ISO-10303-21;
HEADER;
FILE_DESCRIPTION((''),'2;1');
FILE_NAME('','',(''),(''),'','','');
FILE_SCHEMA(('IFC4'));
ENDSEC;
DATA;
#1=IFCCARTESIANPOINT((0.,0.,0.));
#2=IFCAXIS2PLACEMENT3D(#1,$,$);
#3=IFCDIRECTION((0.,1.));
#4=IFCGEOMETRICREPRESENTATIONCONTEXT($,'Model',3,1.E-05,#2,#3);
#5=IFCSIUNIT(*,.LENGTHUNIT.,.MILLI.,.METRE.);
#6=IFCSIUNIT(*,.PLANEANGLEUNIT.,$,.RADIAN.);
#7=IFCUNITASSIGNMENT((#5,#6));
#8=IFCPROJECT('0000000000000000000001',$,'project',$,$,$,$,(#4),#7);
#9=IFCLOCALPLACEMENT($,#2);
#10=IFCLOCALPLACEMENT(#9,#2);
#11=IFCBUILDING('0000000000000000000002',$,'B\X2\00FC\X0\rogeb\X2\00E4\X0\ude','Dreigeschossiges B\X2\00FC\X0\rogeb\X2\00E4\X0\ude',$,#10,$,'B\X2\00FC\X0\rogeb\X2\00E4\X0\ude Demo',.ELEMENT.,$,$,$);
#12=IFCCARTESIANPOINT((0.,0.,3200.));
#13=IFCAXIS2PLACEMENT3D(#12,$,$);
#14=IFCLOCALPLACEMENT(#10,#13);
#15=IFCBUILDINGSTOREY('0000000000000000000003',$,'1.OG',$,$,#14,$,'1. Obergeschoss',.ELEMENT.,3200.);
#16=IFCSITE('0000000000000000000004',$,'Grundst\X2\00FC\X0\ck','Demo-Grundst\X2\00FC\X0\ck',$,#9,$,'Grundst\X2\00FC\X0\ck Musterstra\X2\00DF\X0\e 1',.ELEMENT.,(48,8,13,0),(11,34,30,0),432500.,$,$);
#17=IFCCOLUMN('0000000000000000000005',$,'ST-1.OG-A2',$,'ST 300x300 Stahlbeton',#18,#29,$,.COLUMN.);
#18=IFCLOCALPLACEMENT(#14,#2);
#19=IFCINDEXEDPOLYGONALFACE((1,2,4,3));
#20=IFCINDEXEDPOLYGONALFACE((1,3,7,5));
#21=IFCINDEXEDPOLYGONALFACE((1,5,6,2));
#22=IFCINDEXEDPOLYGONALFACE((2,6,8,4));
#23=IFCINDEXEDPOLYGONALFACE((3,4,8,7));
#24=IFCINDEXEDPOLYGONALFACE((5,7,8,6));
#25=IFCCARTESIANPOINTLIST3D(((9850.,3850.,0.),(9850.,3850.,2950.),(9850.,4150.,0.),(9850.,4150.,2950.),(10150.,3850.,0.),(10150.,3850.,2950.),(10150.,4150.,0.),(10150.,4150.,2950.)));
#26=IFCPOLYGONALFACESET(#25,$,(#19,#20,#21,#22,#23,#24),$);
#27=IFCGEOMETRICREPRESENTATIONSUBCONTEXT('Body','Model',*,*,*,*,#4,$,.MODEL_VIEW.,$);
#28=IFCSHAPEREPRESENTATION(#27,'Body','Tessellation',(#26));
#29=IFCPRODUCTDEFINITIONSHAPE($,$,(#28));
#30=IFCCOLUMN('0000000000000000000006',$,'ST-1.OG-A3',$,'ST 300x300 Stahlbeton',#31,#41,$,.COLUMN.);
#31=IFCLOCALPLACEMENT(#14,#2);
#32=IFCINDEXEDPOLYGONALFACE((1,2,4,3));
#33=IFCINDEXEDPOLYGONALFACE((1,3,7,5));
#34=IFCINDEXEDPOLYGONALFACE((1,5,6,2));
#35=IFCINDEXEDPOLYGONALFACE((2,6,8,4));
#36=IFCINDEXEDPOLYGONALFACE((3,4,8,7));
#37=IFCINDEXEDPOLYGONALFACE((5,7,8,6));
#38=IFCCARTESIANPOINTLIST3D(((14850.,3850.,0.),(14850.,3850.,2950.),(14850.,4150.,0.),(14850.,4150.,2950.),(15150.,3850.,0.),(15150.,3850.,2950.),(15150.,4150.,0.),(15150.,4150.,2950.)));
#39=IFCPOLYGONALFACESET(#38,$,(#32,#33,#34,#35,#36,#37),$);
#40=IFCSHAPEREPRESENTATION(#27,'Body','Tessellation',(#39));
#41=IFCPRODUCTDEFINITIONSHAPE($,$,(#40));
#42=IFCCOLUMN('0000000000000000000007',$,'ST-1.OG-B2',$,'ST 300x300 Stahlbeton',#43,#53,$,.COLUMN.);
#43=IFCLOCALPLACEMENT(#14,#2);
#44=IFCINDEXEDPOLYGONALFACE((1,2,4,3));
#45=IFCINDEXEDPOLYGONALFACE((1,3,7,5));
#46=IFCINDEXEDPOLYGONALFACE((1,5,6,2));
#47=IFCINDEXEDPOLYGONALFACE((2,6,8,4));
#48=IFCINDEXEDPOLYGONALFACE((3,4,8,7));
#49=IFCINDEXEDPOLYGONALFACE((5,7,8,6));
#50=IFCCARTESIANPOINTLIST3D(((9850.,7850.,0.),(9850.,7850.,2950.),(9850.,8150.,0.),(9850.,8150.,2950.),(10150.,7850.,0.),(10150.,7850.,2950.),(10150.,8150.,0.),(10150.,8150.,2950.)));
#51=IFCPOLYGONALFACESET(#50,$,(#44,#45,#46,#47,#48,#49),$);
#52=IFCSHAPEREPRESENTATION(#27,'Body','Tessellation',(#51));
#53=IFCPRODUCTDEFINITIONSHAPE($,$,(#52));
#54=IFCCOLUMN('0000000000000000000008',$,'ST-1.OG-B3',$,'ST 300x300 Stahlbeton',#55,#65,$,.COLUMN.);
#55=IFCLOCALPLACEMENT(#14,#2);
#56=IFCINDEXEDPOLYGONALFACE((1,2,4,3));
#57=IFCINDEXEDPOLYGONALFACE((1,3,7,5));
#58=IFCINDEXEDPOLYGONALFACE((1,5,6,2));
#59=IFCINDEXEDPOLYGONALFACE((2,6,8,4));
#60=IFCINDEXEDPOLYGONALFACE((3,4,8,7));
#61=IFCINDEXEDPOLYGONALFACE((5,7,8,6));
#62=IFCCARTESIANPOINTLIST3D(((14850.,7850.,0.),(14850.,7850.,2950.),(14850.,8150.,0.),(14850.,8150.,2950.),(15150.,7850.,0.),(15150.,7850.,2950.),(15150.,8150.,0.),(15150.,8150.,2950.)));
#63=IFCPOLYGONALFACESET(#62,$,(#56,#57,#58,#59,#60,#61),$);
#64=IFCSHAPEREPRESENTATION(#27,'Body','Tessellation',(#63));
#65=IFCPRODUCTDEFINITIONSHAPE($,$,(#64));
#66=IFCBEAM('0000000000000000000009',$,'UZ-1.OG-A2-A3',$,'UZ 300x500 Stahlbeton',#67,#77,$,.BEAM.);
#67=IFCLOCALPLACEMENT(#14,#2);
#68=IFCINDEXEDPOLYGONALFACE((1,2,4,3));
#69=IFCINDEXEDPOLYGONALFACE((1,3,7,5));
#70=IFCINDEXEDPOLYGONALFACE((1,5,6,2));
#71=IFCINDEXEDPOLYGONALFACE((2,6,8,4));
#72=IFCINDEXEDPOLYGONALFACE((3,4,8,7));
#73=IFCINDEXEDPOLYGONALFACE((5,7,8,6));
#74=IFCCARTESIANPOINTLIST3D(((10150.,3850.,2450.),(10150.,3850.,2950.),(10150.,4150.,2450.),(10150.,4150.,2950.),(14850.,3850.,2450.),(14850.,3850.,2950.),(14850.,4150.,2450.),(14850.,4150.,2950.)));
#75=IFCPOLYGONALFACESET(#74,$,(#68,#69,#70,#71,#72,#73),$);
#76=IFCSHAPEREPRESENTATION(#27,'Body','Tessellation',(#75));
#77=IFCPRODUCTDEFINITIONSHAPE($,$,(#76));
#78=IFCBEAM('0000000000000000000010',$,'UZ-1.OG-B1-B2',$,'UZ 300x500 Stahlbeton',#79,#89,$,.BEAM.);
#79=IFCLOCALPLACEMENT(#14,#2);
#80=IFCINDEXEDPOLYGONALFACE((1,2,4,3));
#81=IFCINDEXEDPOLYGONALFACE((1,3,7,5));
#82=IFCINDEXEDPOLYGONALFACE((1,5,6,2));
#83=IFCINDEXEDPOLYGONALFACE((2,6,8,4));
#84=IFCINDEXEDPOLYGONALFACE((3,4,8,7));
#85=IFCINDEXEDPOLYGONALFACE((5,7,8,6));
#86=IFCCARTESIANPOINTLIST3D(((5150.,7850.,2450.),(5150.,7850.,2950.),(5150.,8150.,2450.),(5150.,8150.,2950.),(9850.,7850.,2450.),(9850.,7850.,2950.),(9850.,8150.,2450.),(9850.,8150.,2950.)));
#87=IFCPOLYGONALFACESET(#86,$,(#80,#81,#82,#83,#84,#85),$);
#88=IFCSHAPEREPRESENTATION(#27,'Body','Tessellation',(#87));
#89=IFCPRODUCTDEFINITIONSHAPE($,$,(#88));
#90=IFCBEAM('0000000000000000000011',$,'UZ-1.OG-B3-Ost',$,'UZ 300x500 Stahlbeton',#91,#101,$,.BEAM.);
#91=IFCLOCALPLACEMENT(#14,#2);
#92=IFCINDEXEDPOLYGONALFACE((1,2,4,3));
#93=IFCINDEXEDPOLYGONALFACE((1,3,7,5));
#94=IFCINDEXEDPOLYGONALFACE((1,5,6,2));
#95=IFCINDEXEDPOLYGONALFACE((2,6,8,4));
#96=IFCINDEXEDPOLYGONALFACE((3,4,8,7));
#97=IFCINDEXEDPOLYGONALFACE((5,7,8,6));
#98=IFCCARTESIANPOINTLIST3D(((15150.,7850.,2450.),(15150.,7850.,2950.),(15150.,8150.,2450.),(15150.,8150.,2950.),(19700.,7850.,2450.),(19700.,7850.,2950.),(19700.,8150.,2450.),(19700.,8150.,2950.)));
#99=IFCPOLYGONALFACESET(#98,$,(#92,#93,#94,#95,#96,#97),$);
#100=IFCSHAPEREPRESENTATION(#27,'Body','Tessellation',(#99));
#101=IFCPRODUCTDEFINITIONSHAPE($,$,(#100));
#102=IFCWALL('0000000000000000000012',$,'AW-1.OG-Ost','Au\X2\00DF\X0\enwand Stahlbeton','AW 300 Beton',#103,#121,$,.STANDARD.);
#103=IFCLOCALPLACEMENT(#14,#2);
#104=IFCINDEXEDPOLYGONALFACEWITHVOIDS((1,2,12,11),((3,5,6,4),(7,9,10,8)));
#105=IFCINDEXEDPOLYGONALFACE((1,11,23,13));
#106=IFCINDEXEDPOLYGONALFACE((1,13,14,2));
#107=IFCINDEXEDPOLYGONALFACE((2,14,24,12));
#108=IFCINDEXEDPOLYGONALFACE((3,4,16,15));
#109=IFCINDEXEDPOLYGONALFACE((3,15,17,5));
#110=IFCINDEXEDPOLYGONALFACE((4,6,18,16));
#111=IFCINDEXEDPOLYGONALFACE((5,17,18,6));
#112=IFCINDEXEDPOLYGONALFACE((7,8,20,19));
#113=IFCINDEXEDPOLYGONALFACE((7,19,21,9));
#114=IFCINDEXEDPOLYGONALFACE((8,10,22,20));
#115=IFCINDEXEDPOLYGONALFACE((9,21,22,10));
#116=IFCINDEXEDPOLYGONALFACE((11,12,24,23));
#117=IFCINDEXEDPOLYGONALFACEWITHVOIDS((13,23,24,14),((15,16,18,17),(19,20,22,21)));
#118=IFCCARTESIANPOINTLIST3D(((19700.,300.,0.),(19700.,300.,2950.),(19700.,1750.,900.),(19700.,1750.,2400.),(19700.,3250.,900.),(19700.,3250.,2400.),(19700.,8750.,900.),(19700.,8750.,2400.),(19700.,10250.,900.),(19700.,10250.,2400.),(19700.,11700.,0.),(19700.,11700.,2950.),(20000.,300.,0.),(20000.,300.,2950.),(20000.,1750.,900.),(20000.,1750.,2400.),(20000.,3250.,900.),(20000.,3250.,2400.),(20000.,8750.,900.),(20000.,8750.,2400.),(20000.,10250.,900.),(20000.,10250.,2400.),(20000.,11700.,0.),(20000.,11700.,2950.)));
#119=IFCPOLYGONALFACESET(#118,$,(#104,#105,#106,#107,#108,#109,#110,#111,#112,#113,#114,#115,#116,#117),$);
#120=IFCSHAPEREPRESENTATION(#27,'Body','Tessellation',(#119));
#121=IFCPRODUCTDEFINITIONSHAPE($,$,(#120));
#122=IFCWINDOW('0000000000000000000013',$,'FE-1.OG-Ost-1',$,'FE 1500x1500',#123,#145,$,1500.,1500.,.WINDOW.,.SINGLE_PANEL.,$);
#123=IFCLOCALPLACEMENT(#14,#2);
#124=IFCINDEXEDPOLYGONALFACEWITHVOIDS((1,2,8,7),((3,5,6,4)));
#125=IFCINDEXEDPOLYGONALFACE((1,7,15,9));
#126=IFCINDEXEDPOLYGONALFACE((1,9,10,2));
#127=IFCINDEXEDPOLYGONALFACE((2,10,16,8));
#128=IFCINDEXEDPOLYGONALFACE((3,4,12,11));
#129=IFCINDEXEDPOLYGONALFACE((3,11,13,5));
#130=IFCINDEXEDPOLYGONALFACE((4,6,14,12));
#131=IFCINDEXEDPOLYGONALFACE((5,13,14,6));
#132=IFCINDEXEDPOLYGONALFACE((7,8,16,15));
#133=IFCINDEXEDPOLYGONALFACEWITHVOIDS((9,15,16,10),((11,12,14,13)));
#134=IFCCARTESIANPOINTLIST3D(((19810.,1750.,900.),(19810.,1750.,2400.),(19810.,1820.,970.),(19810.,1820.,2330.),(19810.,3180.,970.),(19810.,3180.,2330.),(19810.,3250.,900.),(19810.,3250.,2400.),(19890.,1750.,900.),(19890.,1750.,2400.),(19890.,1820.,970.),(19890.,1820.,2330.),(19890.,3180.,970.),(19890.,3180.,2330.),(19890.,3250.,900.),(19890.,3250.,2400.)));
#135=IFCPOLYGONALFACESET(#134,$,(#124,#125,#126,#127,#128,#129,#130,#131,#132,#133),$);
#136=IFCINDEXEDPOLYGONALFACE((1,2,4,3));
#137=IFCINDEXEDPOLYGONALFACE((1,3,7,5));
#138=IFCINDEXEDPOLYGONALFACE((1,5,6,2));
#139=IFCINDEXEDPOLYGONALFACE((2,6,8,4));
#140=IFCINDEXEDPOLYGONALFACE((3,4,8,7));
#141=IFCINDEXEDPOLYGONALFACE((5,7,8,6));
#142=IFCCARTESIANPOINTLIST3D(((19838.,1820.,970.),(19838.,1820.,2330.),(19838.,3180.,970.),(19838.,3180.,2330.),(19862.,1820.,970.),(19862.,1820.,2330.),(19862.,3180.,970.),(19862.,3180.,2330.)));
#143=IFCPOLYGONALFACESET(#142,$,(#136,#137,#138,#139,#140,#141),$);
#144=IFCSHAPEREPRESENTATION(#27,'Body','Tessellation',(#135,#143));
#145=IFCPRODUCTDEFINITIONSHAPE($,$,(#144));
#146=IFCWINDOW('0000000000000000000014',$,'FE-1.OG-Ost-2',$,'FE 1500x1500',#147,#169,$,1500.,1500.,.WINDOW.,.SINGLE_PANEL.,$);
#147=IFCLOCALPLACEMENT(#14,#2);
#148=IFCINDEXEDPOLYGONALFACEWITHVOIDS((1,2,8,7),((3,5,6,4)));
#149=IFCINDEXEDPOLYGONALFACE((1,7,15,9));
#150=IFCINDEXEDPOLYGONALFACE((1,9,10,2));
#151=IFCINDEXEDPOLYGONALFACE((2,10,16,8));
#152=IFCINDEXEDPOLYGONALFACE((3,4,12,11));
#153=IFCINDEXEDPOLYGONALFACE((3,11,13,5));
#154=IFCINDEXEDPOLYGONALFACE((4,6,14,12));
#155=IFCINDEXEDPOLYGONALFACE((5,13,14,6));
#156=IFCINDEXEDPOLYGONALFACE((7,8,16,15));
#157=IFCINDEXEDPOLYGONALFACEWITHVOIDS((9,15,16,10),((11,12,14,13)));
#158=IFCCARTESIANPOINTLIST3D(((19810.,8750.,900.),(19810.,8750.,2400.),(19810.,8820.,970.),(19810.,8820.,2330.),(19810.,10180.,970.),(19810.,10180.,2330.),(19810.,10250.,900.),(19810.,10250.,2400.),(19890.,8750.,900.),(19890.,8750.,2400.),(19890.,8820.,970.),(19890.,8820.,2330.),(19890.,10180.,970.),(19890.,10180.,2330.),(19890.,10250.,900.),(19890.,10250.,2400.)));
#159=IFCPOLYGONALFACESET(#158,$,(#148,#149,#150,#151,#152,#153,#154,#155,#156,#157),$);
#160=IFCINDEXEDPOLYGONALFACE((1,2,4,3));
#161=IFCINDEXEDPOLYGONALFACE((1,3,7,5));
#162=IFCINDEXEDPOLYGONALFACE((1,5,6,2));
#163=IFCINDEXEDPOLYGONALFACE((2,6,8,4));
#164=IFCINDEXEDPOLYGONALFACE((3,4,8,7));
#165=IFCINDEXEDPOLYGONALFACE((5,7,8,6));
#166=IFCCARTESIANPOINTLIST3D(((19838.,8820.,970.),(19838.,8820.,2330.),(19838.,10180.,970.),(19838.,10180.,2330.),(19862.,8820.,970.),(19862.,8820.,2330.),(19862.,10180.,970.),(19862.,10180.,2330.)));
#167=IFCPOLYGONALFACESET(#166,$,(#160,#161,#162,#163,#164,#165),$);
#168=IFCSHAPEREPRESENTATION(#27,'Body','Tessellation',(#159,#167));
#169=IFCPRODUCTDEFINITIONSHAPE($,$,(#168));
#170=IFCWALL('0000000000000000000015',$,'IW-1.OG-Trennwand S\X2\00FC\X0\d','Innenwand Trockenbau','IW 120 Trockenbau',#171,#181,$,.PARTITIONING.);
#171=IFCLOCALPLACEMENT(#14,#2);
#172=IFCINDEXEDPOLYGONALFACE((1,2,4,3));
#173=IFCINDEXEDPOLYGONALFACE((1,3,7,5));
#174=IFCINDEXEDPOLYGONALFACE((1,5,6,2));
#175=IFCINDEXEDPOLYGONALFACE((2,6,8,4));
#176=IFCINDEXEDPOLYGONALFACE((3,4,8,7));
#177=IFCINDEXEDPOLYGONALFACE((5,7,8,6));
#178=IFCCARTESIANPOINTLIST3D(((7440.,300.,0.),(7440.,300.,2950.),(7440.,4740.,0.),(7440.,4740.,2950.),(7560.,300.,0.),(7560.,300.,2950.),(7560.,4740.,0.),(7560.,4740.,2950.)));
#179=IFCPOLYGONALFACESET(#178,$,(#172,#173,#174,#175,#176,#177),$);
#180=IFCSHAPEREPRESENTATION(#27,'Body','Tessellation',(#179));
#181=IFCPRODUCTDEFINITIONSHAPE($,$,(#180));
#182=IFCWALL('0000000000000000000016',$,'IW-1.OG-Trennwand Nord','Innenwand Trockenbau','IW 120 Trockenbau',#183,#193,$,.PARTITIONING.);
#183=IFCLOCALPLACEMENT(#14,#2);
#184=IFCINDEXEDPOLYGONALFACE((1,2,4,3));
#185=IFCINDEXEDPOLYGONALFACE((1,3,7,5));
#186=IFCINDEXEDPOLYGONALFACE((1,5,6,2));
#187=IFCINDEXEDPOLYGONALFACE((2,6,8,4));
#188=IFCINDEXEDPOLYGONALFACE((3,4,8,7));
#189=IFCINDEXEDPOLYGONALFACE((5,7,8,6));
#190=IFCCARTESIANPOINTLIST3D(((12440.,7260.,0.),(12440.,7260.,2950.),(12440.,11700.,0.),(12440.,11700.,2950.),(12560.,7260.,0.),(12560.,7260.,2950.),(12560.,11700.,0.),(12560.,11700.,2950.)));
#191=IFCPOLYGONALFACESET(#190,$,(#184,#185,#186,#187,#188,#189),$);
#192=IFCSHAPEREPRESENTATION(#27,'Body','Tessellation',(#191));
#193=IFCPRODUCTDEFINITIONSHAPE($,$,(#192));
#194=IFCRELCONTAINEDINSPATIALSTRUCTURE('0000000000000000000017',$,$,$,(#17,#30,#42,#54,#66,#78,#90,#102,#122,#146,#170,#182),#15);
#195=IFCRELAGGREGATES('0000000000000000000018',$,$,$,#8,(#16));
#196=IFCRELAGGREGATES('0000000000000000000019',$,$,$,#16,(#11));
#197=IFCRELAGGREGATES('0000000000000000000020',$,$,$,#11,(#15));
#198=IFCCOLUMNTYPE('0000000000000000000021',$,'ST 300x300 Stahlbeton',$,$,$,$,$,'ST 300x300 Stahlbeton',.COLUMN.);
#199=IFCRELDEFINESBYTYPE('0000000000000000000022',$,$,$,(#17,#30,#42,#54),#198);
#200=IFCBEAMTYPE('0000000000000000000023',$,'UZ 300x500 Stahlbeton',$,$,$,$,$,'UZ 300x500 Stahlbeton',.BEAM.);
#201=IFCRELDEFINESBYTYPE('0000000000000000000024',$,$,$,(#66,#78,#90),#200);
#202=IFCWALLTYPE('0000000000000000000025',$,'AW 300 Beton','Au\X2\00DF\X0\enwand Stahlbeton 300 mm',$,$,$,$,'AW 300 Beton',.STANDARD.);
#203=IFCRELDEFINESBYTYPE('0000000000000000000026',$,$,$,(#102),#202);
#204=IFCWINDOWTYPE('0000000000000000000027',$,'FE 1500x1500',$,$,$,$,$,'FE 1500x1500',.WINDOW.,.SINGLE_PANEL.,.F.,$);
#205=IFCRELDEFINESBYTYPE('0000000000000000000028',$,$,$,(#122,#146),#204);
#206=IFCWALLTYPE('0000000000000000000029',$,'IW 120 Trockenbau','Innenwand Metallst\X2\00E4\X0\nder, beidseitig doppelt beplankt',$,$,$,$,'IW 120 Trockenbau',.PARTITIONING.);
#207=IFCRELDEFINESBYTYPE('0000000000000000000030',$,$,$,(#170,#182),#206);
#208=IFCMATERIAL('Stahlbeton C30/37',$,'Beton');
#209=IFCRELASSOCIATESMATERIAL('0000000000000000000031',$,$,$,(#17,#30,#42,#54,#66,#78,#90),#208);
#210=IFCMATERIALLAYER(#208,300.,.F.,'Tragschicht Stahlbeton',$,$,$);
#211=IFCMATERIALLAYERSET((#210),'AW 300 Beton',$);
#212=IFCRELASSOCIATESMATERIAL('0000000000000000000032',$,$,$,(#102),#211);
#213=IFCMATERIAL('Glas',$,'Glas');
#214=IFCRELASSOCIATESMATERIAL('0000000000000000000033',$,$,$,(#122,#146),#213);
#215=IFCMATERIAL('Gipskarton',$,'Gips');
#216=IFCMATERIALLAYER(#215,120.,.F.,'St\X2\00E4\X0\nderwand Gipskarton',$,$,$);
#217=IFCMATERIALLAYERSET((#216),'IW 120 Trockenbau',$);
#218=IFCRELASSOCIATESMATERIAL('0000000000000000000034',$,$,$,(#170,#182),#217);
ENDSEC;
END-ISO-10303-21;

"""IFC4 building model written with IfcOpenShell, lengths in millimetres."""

from ifc_helpers import new_model, si_unit, direction, frame, frame_2d, origin, origin_2d, place, context, subcontext, project, spatial, polyline, rectangle, outline, extrude, material, layer, layer_set, layer_usage, type_object, element, fill, save


model = new_model("IFC4")

# Units and contexts
model_context = context("Model", 3, precision=1e-05, world=origin(), true_north=direction((0.0, 1.0)))
body_context = subcontext(model_context, "Body", "Model", "MODEL_VIEW")
ifc_project = project(units=[si_unit("LENGTHUNIT", "METRE", prefix="MILLI"), si_unit("PLANEANGLEUNIT", "RADIAN")], contexts=[model_context])

# Site, building, storey
site_placement = place(None, origin())
site = spatial("IfcSite", under=ifc_project, at=site_placement, Name="Grundstück", Description="Demo-Grundstück", LongName="Grundstück Musterstraße 1", CompositionType="ELEMENT", RefLatitude=(48, 8, 13, 0), RefLongitude=(11, 34, 30, 0), RefElevation=432500.0)
building_placement = place(site_placement, origin())
building = spatial("IfcBuilding", under=site, at=building_placement, Name="Bürogebäude", Description="Dreigeschossiges Bürogebäude", LongName="Bürogebäude Demo", CompositionType="ELEMENT")
storey_placement = place(building_placement, frame((0.0, 0.0, 3200.0)))
storey = spatial("IfcBuildingStorey", under=building, at=storey_placement, Name="1.OG", LongName="1. Obergeschoss", CompositionType="ELEMENT", Elevation=3200.0)

# Columns
ifc_material_1 = material(Name="Stahlbeton C30/37", Category="Beton")
column_type = type_object("IfcColumnType", Name="ST 300x300 Stahlbeton", ElementType="ST 300x300 Stahlbeton", PredefinedType="COLUMN")
for number, where, name in (
    (1, (10000.0, 4000.0, 0.0), "ST-1.OG-A2"),
    (2, (15000.0, 4000.0, 0.0), "ST-1.OG-A3"),
    (3, (10000.0, 8000.0, 0.0), "ST-1.OG-B2"),
    (4, (15000.0, 8000.0, 0.0), "ST-1.OG-B3"),
):
    element("IfcColumn", number, at=place(storey_placement, frame(where)), inside=storey, type_object=column_type, material=ifc_material_1, Name=name, ObjectType="ST 300x300 Stahlbeton", PredefinedType="COLUMN", context=body_context, shape_type="SweptSolid", body=[
        extrude(rectangle(XDim=300.0, YDim=300.0, at=origin_2d()), origin(), (0.0, 0.0, 1.0), 2950.0),
    ])

# Beams
beam_type = type_object("IfcBeamType", Name="UZ 300x500 Stahlbeton", ElementType="UZ 300x500 Stahlbeton", PredefinedType="BEAM")
for number, where, name in (
    (5, (10150.0, 4000.0, 2700.0), "UZ-1.OG-A2-A3"),
    (6, (5150.0, 8000.0, 2700.0), "UZ-1.OG-B1-B2"),
):
    element("IfcBeam", number, at=place(storey_placement, frame(where)), inside=storey, type_object=beam_type, material=ifc_material_1, Name=name, ObjectType="UZ 300x500 Stahlbeton", PredefinedType="BEAM", context=body_context, shape_type="SweptSolid", body=[
        extrude(rectangle(XDim=300.0, YDim=500.0, at=origin_2d()), frame((0.0, 0.0, 0.0), z_axis=(1.0, 0.0, 0.0), x_axis=(0.0, 1.0, 0.0)), (0.0, 0.0, 1.0), 4700.0),
    ])
beam_placement = place(storey_placement, frame((15150.0, 8000.0, 2700.0)))
element("IfcBeam", 7, at=beam_placement, inside=storey, type_object=beam_type, material=ifc_material_1, Name="UZ-1.OG-B3-Ost", ObjectType="UZ 300x500 Stahlbeton", PredefinedType="BEAM", context=body_context, shape_type="SweptSolid", body=[
    extrude(rectangle(XDim=300.0, YDim=500.0, at=origin_2d()), frame((0.0, 0.0, 0.0), z_axis=(1.0, 0.0, 0.0), x_axis=(0.0, 1.0, 0.0)), (0.0, 0.0, 1.0), 4550.0),
])

# Wall, openings, windows
ifc_layer_1 = layer(ifc_material_1, 300.0, ventilated=False, Name="Tragschicht Stahlbeton")
ifc_layer_set_1 = layer_set([ifc_layer_1], Name="AW 300 Beton")
ifc_layer_usage_1 = layer_usage(ifc_layer_set_1, "AXIS2", "POSITIVE", -150.0)
wall_type_1 = type_object("IfcWallType", Name="AW 300 Beton", Description="Außenwand Stahlbeton 300 mm", ElementType="AW 300 Beton", PredefinedType="STANDARD")
wall_placement = place(storey_placement, frame((19850.0, 300.0, 0.0), z_axis=(0.0, 0.0, 1.0), x_axis=(0.0, 1.0, 0.0)))
wall = element("IfcWall", 8, at=wall_placement, inside=storey, type_object=wall_type_1, material=ifc_layer_usage_1, Name="AW-1.OG-Ost", Description="Außenwand Stahlbeton", ObjectType="AW 300 Beton", PredefinedType="STANDARD", context=body_context, shape_type="SweptSolid", body=[
    extrude(rectangle(XDim=11400.0, YDim=300.0, at=frame_2d((5700.0, 0.0))), origin(), (0.0, 0.0, 1.0), 2950.0),
])
opening_1_placement = place(wall_placement, frame((2200.0, 0.0, 900.0)))
opening_1 = element("IfcOpeningElement", 9, at=opening_1_placement, cuts=wall, PredefinedType="OPENING", context=body_context, shape_type="SweptSolid", body=[
    extrude(rectangle(XDim=1500.0, YDim=340.0, at=origin_2d()), origin(), (0.0, 0.0, 1.0), 1500.0),
])
opening_2_placement = place(wall_placement, frame((9200.0, 0.0, 900.0)))
opening_2 = element("IfcOpeningElement", 10, at=opening_2_placement, cuts=wall, PredefinedType="OPENING", context=body_context, shape_type="SweptSolid", body=[
    extrude(rectangle(XDim=1500.0, YDim=340.0, at=origin_2d()), origin(), (0.0, 0.0, 1.0), 1500.0),
])
ifc_material_2 = material(Name="Glas", Category="Glas")
window_type = type_object("IfcWindowType", Name="FE 1500x1500", ElementType="FE 1500x1500", ParameterTakesPrecedence=False, PartitioningType="SINGLE_PANEL", PredefinedType="WINDOW")
window_1_placement = place(opening_1_placement, origin())
window_1 = element("IfcWindow", 11, at=window_1_placement, inside=storey, type_object=window_type, material=ifc_material_2, Name="FE-1.OG-Ost-1", ObjectType="FE 1500x1500", OverallHeight=1500.0, OverallWidth=1500.0, PartitioningType="SINGLE_PANEL", PredefinedType="WINDOW", context=body_context, shape_type="SweptSolid", body=[
    extrude(outline(polyline([(-750.0, 0.0), (750.0, 0.0), (750.0, 1500.0), (-750.0, 1500.0), (-750.0, 0.0)]), holes=[polyline([(-680.0, 70.0), (680.0, 70.0), (680.0, 1430.0), (-680.0, 1430.0), (-680.0, 70.0)])]), frame((0.0, 40.0, 0.0), z_axis=(0.0, -1.0, 0.0), x_axis=(1.0, 0.0, 0.0)), (0.0, 0.0, 1.0), 80.0),
    extrude(rectangle(XDim=1360.0, YDim=24.0, at=origin_2d()), frame((0.0, 0.0, 70.0)), (0.0, 0.0, 1.0), 1360.0),
])
fill(opening_1, window_1)
window_2_placement = place(opening_2_placement, origin())
window_2 = element("IfcWindow", 12, at=window_2_placement, inside=storey, type_object=window_type, material=ifc_material_2, Name="FE-1.OG-Ost-2", ObjectType="FE 1500x1500", OverallHeight=1500.0, OverallWidth=1500.0, PartitioningType="SINGLE_PANEL", PredefinedType="WINDOW", context=body_context, shape_type="SweptSolid", body=[
    extrude(outline(polyline([(-750.0, 0.0), (750.0, 0.0), (750.0, 1500.0), (-750.0, 1500.0), (-750.0, 0.0)]), holes=[polyline([(-680.0, 70.0), (680.0, 70.0), (680.0, 1430.0), (-680.0, 1430.0), (-680.0, 70.0)])]), frame((0.0, 40.0, 0.0), z_axis=(0.0, -1.0, 0.0), x_axis=(1.0, 0.0, 0.0)), (0.0, 0.0, 1.0), 80.0),
    extrude(rectangle(XDim=1360.0, YDim=24.0, at=origin_2d()), frame((0.0, 0.0, 70.0)), (0.0, 0.0, 1.0), 1360.0),
])
fill(opening_2, window_2)

# Walls
ifc_material_3 = material(Name="Gipskarton", Category="Gips")
ifc_layer_2 = layer(ifc_material_3, 120.0, ventilated=False, Name="Ständerwand Gipskarton")
ifc_layer_set_2 = layer_set([ifc_layer_2], Name="IW 120 Trockenbau")
ifc_layer_usage_2 = layer_usage(ifc_layer_set_2, "AXIS2", "POSITIVE", -60.0)
wall_type_2 = type_object("IfcWallType", Name="IW 120 Trockenbau", Description="Innenwand Metallständer, beidseitig doppelt beplankt", ElementType="IW 120 Trockenbau", PredefinedType="PARTITIONING")
for number, where, z_axis, x_axis, name in (
    (13, (7500.0, 300.0, 0.0), (0.0, 0.0, 1.0), (0.0, 1.0, 0.0), "IW-1.OG-Trennwand Süd"),
    (14, (12500.0, 7260.0, 0.0), (0.0, 0.0, 1.0), (0.0, 1.0, 0.0), "IW-1.OG-Trennwand Nord"),
):
    element("IfcWall", number, at=place(storey_placement, frame(where, z_axis=z_axis, x_axis=x_axis)), inside=storey, type_object=wall_type_2, material=ifc_layer_usage_2, Name=name, Description="Innenwand Trockenbau", ObjectType="IW 120 Trockenbau", PredefinedType="PARTITIONING", context=body_context, shape_type="SweptSolid", body=[
        extrude(rectangle(XDim=4440.0, YDim=120.0, at=frame_2d((2220.0, 0.0))), origin(), (0.0, 0.0, 1.0), 2950.0),
    ])

save(model, "model.ifc")
